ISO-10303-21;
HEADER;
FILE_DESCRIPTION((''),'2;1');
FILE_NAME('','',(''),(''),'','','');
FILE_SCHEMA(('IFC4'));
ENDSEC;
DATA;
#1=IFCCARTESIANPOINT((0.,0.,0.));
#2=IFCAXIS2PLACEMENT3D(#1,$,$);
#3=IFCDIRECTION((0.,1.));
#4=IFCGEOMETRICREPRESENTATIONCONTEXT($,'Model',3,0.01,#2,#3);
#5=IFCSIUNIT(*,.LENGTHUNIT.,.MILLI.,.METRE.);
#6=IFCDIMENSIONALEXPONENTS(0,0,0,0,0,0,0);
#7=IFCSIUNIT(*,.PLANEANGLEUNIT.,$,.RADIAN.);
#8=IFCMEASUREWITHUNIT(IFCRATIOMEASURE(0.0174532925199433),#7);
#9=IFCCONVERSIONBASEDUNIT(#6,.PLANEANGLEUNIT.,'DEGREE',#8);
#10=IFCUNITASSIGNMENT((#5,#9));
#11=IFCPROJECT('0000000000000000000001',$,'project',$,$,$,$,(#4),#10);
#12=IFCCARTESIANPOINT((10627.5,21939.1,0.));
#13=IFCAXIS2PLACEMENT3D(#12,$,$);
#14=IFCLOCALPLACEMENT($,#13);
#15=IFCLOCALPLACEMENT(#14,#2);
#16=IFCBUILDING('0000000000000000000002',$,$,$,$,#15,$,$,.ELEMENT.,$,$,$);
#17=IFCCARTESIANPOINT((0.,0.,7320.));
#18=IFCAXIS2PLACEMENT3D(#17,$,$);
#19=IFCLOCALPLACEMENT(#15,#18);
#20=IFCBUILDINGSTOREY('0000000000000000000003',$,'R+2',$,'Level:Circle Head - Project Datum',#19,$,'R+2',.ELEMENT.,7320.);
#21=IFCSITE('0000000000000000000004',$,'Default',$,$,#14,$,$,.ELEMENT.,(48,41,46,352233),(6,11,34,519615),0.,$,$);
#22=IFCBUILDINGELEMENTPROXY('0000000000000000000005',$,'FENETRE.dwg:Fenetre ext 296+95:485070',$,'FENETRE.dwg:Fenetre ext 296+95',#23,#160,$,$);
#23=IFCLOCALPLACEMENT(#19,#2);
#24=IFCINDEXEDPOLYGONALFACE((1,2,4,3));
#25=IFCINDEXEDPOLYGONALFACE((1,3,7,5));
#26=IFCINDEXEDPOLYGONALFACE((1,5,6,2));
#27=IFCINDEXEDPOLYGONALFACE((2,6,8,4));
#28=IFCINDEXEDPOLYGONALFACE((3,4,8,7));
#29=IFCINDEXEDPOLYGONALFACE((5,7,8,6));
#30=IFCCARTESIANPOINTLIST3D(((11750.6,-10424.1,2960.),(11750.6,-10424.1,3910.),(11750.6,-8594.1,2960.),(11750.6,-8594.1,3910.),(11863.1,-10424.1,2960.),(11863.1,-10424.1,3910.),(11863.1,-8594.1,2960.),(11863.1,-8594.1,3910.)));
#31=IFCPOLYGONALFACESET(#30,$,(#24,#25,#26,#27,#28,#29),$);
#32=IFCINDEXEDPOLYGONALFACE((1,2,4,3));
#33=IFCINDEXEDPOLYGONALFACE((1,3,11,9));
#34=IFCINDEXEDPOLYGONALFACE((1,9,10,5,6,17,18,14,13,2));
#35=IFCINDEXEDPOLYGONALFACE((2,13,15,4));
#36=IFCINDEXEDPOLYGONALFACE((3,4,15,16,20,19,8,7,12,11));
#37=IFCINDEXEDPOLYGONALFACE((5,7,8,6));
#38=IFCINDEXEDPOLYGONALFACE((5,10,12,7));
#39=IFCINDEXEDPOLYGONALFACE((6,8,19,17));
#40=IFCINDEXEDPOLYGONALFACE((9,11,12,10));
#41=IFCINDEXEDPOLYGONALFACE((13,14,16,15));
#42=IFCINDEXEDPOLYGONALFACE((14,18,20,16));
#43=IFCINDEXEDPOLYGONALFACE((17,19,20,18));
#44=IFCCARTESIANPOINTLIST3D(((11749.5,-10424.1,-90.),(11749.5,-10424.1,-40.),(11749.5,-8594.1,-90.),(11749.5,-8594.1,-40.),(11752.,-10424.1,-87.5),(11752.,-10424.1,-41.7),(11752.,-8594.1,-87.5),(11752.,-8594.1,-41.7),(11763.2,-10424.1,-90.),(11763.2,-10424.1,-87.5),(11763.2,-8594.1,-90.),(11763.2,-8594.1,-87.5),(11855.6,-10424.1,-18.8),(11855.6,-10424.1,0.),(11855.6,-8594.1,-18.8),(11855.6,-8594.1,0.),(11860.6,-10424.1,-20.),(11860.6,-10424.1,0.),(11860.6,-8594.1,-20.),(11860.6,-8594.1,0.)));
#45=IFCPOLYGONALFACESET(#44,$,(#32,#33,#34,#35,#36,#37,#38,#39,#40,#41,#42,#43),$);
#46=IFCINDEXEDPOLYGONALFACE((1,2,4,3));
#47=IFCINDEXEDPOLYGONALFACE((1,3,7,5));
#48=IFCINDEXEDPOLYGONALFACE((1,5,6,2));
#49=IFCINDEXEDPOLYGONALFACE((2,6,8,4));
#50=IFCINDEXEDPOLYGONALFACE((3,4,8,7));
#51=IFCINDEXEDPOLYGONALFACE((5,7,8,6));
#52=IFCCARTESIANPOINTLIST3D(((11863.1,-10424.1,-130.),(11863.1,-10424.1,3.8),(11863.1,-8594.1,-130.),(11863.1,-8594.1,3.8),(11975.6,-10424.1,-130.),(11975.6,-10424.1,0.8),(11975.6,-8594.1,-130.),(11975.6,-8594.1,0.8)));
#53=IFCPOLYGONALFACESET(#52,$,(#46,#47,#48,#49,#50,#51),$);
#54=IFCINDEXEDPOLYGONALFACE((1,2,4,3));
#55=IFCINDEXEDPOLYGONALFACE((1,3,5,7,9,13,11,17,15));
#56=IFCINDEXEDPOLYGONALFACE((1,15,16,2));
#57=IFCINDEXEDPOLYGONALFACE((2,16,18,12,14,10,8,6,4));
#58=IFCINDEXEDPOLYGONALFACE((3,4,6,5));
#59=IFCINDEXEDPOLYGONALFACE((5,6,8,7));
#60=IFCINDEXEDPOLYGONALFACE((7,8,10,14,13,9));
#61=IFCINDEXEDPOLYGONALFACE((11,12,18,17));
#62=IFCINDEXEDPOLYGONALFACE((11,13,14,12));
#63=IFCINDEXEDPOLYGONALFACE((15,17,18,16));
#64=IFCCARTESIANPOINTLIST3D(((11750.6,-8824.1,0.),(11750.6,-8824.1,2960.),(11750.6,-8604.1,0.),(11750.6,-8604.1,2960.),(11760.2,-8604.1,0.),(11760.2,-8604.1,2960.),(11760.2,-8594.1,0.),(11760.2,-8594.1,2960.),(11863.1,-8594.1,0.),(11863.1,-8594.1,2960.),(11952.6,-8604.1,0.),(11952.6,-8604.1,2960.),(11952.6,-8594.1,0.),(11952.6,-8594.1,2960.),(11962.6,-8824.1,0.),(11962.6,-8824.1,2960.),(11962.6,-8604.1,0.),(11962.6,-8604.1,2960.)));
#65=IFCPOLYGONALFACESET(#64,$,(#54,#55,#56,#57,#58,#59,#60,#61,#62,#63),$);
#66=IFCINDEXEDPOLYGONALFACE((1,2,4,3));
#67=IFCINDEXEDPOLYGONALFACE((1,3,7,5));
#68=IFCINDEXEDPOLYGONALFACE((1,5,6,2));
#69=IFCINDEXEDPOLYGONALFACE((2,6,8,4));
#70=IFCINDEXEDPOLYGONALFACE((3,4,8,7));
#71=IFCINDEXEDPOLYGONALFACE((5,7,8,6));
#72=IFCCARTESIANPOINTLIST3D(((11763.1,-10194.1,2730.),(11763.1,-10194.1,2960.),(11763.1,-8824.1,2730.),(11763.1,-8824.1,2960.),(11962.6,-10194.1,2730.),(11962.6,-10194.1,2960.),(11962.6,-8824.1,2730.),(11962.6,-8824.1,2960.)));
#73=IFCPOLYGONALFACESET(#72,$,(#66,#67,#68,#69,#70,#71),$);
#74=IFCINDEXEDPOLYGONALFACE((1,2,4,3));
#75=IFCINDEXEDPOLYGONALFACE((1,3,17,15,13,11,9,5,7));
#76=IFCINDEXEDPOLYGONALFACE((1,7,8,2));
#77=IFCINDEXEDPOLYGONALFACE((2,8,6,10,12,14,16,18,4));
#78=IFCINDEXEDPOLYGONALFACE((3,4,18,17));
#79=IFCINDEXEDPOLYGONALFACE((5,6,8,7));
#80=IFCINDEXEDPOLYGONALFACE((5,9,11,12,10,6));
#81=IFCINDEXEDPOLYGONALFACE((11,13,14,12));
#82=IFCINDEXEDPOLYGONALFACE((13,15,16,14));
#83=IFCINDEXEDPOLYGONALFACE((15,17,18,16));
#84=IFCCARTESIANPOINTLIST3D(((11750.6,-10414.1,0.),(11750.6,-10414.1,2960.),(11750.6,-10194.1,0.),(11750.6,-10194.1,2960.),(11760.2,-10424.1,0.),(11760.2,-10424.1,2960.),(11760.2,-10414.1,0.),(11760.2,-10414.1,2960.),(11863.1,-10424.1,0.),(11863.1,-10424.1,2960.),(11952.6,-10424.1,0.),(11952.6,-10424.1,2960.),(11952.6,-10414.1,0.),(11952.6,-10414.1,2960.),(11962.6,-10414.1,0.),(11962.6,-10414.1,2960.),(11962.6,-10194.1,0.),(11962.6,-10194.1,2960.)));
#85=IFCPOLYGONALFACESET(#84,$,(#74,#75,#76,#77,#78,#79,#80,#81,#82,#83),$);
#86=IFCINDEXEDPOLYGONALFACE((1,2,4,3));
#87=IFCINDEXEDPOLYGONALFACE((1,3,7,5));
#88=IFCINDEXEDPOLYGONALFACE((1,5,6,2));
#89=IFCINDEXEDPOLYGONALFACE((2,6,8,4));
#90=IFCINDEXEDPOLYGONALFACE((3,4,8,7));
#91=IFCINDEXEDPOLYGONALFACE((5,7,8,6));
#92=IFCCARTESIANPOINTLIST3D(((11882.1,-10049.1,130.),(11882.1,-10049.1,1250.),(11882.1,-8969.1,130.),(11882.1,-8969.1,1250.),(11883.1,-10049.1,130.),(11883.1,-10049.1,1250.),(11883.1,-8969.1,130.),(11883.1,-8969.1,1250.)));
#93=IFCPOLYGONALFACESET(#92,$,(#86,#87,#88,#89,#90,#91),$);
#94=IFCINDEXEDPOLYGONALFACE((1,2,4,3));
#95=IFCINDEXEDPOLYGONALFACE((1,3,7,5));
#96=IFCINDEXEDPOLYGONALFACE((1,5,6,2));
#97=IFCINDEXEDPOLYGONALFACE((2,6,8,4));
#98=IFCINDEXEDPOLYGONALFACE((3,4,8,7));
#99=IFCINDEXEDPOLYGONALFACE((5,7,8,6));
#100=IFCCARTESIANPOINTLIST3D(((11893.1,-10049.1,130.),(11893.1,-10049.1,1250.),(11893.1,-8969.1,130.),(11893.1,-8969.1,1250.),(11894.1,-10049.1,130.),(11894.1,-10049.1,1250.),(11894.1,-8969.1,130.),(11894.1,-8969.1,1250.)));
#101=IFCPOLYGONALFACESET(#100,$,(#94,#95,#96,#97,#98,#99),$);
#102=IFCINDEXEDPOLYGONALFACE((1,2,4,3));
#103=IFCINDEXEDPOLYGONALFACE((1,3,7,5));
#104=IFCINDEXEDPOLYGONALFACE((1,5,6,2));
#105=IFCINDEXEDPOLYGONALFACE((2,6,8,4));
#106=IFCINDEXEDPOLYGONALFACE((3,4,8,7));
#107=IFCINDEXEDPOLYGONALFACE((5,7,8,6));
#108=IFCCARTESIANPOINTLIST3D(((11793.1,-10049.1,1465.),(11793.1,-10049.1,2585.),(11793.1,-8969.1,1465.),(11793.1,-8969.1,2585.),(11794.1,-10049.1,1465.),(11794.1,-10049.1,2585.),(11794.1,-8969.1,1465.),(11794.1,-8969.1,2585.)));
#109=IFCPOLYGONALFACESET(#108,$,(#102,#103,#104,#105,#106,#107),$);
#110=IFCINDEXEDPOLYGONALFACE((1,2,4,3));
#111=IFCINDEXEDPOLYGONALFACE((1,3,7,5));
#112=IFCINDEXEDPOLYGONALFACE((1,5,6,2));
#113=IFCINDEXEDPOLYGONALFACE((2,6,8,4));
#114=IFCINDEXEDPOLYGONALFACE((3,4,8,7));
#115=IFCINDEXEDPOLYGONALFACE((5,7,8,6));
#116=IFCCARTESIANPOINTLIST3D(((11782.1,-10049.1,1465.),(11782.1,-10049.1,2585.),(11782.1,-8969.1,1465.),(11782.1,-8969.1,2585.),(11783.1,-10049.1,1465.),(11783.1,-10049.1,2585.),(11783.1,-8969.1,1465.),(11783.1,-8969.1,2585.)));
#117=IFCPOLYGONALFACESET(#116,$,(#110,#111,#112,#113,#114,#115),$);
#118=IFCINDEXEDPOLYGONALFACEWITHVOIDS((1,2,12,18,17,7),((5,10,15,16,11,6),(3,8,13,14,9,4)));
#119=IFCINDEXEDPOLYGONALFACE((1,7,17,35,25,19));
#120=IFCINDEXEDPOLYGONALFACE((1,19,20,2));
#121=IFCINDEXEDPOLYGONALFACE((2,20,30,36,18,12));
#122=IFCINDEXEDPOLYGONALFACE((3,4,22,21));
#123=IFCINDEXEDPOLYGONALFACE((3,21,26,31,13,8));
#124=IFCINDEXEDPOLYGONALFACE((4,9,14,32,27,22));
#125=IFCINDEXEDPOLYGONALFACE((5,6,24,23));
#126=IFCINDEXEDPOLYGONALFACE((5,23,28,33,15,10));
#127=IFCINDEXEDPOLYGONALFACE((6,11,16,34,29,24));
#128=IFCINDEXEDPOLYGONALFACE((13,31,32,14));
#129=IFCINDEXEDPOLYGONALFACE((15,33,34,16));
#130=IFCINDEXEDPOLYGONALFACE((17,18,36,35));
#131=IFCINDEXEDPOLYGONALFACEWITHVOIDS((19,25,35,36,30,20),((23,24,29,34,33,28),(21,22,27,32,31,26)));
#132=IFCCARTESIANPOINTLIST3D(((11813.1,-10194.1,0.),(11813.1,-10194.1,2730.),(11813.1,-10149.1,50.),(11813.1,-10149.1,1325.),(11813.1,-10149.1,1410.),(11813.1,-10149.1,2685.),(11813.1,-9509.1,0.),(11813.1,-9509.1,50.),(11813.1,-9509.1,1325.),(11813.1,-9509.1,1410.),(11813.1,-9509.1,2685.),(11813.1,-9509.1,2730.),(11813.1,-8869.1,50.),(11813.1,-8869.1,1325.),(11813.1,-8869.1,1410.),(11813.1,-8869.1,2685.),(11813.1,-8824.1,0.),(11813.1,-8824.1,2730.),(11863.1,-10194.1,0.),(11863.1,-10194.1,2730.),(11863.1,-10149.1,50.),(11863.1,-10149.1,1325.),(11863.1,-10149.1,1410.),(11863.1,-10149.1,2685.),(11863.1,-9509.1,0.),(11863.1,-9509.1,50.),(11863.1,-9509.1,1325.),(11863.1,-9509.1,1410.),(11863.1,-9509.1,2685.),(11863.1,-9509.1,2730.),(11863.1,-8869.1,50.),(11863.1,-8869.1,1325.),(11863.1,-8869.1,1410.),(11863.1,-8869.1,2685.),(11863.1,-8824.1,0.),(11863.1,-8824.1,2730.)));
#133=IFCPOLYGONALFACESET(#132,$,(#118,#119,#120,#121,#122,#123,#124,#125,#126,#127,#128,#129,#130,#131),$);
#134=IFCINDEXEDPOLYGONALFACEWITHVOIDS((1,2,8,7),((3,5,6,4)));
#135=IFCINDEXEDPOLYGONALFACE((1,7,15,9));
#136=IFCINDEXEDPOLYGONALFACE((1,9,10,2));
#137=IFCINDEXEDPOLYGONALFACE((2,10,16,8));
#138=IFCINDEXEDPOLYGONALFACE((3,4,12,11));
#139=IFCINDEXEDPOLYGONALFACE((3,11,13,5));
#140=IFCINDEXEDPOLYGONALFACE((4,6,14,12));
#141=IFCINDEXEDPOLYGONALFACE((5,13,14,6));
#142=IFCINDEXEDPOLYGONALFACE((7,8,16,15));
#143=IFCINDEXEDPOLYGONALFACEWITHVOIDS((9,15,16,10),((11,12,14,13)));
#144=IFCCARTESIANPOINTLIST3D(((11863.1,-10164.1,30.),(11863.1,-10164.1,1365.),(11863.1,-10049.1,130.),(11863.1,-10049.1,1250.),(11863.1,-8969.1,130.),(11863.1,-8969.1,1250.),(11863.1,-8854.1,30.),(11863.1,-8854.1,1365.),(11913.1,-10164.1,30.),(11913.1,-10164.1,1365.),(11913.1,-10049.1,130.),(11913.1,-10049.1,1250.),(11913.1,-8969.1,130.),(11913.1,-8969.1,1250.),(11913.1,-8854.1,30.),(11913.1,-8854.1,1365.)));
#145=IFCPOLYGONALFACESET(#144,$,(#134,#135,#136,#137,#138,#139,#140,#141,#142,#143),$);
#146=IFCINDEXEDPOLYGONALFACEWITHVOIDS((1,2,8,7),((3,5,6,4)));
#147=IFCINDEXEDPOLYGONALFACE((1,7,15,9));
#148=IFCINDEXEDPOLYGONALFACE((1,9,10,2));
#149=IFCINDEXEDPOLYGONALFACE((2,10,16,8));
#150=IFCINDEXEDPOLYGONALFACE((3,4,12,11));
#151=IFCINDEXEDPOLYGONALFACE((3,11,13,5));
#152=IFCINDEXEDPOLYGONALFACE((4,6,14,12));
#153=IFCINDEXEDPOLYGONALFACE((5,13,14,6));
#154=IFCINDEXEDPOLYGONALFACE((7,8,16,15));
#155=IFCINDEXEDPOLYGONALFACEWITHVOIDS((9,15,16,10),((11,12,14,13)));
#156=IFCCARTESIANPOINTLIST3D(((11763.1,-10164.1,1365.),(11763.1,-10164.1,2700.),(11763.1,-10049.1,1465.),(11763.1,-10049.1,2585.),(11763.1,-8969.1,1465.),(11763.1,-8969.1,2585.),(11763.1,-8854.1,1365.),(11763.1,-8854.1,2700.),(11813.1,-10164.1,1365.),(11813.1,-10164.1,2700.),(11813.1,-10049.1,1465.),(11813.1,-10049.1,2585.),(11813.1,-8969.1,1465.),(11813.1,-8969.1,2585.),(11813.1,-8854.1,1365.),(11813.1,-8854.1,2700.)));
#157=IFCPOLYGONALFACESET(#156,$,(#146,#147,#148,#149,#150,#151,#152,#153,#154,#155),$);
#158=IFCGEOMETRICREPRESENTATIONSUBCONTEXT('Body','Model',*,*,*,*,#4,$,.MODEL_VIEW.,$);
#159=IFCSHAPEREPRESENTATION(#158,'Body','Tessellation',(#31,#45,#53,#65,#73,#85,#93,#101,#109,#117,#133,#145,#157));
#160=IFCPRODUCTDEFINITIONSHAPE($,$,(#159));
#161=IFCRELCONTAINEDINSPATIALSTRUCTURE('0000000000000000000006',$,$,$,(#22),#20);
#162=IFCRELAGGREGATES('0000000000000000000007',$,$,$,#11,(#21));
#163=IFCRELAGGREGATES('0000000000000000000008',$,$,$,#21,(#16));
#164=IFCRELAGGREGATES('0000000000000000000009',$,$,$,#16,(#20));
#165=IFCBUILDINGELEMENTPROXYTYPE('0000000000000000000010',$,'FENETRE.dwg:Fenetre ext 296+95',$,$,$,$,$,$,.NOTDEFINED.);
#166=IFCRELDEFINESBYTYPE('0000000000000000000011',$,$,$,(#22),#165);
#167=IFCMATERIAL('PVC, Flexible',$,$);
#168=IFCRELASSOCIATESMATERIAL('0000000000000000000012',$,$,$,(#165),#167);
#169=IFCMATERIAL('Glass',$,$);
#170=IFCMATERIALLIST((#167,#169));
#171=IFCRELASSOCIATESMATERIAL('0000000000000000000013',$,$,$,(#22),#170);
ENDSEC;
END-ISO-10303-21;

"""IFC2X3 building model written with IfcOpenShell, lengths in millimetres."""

from ifc_helpers import new_model, entity, si_unit, converted_unit, direction, frame, frame_2d, origin, origin_2d_with_axis, place, context, subcontext, project, spatial, polyline, rectangle, outline, extrude, source, transform, mapped, material, material_list, type_object, type_shapes, element, save


model = new_model("IFC2X3")

# Units and contexts
model_context = context("Model", 3, precision=0.01, world=origin(), true_north=direction((0.0, 1.0)))
body_context = subcontext(model_context, "Body", "Model", "MODEL_VIEW")
ifc_project = project(units=[si_unit("LENGTHUNIT", "METRE", prefix="MILLI"), converted_unit("PLANEANGLEUNIT", "DEGREE", entity("IfcRatioMeasure", 0.0174532925199433), si_unit("PLANEANGLEUNIT", "RADIAN"), dimensions=[0, 0, 0, 0, 0, 0, 0])], contexts=[model_context])

# Site, building, storey
site_placement = place(None, frame((10627.5, 21939.1, 0.0)))
site = spatial("IfcSite", under=ifc_project, at=site_placement, Name="Default", CompositionType="ELEMENT", RefLatitude=(48, 41, 46, 352233), RefLongitude=(6, 11, 34, 519615), RefElevation=0.0)
building_placement = place(site_placement, origin())
building = spatial("IfcBuilding", under=site, at=building_placement, CompositionType="ELEMENT")
storey_placement = place(building_placement, frame((0.0, 0.0, 7320.0)))
storey = spatial("IfcBuildingStorey", under=building, at=storey_placement, Name="R+2", ObjectType="Level:Circle Head - Project Datum", LongName="R+2", CompositionType="ELEMENT", Elevation=7320.0)

# Building element proxy
ifc_material_1 = material(Name="PVC, Flexible")
ifc_material_2 = material(Name="Glass")
building_element_proxy_type_1 = type_object("IfcBuildingElementProxyType", Name="FENETRE.dwg:Fenetre ext 296+95", PredefinedType="NOTDEFINED", material=ifc_material_1)
shared_shape_1 = source(origin(), body_context, "Body", "SweptSolid", [
    extrude(rectangle(XDim=1830.0, YDim=112.5, at=origin_2d_with_axis()), frame((-10.4, 56.3, 2960.0), z_axis=(0.0, 0.0, 1.0), x_axis=(-1.0, 0.0, 0.0)), (0.0, 0.0, 1.0), 950.0),
    extrude(outline(polyline([(-68.6, -14.4), (-72.5, -34.0), (-67.6, -35.0), (-63.9, -16.6), (44.3, -16.6), (54.1, 32.5), (40.6, 35.2), (40.1, 32.7), (51.2, 30.5), (42.2, -14.4), (-68.6, -14.4)])), frame((-925.4, 66.9, -47.5), z_axis=(-1.0, 0.0, 0.0), x_axis=(0.0, 0.980599, -0.196027)), (0.0, 0.0, -1.0), 1830.0),
    extrude(outline(polyline([(-64.7, -56.3), (66.2, -56.3), (66.2, 56.3), (-67.7, 56.3), (-64.7, -56.3)])), frame((-925.4, -56.3, -63.8), z_axis=(1.0, 0.0, 0.0), x_axis=(0.0, 0.0, -1.0)), (0.0, 0.0, 1.0), 1830.0),
    extrude(outline(polyline([(-55.6, 97.0), (-55.6, -5.9), (-55.6, -95.4), (-45.6, -95.4), (-45.6, -105.4), (174.4, -105.4), (174.4, 106.6), (-45.6, 106.6), (-45.6, 97.0), (-55.6, 97.0)])), frame((849.0, 5.9, 0.0), z_axis=(0.0, 0.0, -1.0), x_axis=(-1.0, 0.0, 0.0)), (0.0, 0.0, -1.0), 2960.0),
    extrude(rectangle(XDim=199.5, YDim=1370.0, at=origin_2d_with_axis()), frame((-10.4, 0.3, 2730.0), z_axis=(0.0, 0.0, 1.0), x_axis=(0.0, 1.0, 0.0)), (0.0, 0.0, 1.0), 230.0),
    extrude(outline(polyline([(-97.0, -55.6), (5.9, -55.6), (95.4, -55.6), (95.4, -45.6), (105.4, -45.6), (105.4, 174.4), (-106.6, 174.4), (-106.6, -45.6), (-97.0, -45.6), (-97.0, -55.6)])), frame((-869.9, 5.9, 0.0), z_axis=(0.0, 0.0, 1.0), x_axis=(0.0, -1.0, 0.0)), (0.0, 0.0, 1.0), 2960.0),
    extrude(rectangle(XDim=1.0, YDim=1080.0, at=origin_2d_with_axis()), frame((-10.4, -19.5, 130.0), z_axis=(0.0, 0.0, 1.0), x_axis=(0.0, 1.0, 0.0)), (0.0, 0.0, 1.0), 1120.0),
    extrude(rectangle(XDim=1.0, YDim=1080.0, at=frame_2d((0.0, 0.0), x_axis=(1.0, 0.0))), frame((-10.4, -30.5, 130.0), z_axis=(0.0, 0.0, 1.0), x_axis=(0.0, 1.0, 0.0)), (0.0, 0.0, 1.0), 1120.0),
    extrude(rectangle(XDim=1.0, YDim=1080.0, at=frame_2d((0.0, 0.0), x_axis=(1.0, 0.0))), frame((-10.4, 69.5, 1465.0), z_axis=(0.0, 0.0, 1.0), x_axis=(0.0, 1.0, 0.0)), (0.0, 0.0, 1.0), 1120.0),
    extrude(rectangle(XDim=1.0, YDim=1080.0, at=frame_2d((0.0, 0.0), x_axis=(1.0, 0.0))), frame((-10.4, 80.5, 1465.0), z_axis=(0.0, 0.0, 1.0), x_axis=(0.0, 1.0, 0.0)), (0.0, 0.0, 1.0), 1120.0),
    extrude(outline(polyline([(-685.0, -1365.0), (0.0, -1365.0), (685.0, -1365.0), (685.0, 1365.0), (0.0, 1365.0), (-685.0, 1365.0), (-685.0, -1365.0)]), holes=[polyline([(-640.0, -1320.0), (-640.0, -45.0), (0.0, -45.0), (640.0, -45.0), (640.0, -1320.0), (0.0, -1320.0), (-640.0, -1320.0)]), polyline([(-640.0, 40.0), (-640.0, 1315.0), (0.0, 1315.0), (640.0, 1315.0), (640.0, 40.0), (0.0, 40.0), (-640.0, 40.0)])]), frame((-10.4, 0.0, 1365.0), z_axis=(0.0, 1.0, 0.0), x_axis=(1.0, 0.0, 0.0)), (0.0, 0.0, 1.0), 50.0),
    extrude(outline(polyline([(-655.0, -667.5), (655.0, -667.5), (655.0, 667.5), (-655.0, 667.5), (-655.0, -667.5)]), holes=[polyline([(-540.0, 552.5), (540.0, 552.5), (540.0, -567.5), (-540.0, -567.5), (-540.0, 552.5)])]), frame((-10.4, -50.0, 697.5), z_axis=(0.0, 1.0, 0.0), x_axis=(-1.0, 0.0, 0.0)), (0.0, 0.0, 1.0), 50.0),
    extrude(outline(polyline([(-655.0, -667.5), (655.0, -667.5), (655.0, 667.5), (-655.0, 667.5), (-655.0, -667.5)]), holes=[polyline([(-540.0, 552.5), (540.0, 552.5), (540.0, -567.5), (-540.0, -567.5), (-540.0, 552.5)])]), frame((-10.4, 50.0, 2032.5), z_axis=(0.0, 1.0, 0.0), x_axis=(-1.0, 0.0, 0.0)), (0.0, 0.0, 1.0), 50.0),
])
type_shapes(building_element_proxy_type_1, [shared_shape_1])
ifc_material_list_1 = material_list([ifc_material_1, ifc_material_2])
proxy_1_placement = place(storey_placement, frame((11863.1, -9498.7, 0.0), z_axis=(0.0, 0.0, 1.0), x_axis=(0.0, 1.0, 0.0)))
element("IfcBuildingElementProxy", 1, at=proxy_1_placement, inside=storey, type_object=building_element_proxy_type_1, material=ifc_material_list_1, Name="FENETRE.dwg:Fenetre ext 296+95:485070", ObjectType="FENETRE.dwg:Fenetre ext 296+95", context=body_context, shape_type="MappedRepresentation", body=[
    mapped(shared_shape_1, transform((0.0, 0.0, 0.0), scale=1.0)),
])

save(model, "model.ifc")
